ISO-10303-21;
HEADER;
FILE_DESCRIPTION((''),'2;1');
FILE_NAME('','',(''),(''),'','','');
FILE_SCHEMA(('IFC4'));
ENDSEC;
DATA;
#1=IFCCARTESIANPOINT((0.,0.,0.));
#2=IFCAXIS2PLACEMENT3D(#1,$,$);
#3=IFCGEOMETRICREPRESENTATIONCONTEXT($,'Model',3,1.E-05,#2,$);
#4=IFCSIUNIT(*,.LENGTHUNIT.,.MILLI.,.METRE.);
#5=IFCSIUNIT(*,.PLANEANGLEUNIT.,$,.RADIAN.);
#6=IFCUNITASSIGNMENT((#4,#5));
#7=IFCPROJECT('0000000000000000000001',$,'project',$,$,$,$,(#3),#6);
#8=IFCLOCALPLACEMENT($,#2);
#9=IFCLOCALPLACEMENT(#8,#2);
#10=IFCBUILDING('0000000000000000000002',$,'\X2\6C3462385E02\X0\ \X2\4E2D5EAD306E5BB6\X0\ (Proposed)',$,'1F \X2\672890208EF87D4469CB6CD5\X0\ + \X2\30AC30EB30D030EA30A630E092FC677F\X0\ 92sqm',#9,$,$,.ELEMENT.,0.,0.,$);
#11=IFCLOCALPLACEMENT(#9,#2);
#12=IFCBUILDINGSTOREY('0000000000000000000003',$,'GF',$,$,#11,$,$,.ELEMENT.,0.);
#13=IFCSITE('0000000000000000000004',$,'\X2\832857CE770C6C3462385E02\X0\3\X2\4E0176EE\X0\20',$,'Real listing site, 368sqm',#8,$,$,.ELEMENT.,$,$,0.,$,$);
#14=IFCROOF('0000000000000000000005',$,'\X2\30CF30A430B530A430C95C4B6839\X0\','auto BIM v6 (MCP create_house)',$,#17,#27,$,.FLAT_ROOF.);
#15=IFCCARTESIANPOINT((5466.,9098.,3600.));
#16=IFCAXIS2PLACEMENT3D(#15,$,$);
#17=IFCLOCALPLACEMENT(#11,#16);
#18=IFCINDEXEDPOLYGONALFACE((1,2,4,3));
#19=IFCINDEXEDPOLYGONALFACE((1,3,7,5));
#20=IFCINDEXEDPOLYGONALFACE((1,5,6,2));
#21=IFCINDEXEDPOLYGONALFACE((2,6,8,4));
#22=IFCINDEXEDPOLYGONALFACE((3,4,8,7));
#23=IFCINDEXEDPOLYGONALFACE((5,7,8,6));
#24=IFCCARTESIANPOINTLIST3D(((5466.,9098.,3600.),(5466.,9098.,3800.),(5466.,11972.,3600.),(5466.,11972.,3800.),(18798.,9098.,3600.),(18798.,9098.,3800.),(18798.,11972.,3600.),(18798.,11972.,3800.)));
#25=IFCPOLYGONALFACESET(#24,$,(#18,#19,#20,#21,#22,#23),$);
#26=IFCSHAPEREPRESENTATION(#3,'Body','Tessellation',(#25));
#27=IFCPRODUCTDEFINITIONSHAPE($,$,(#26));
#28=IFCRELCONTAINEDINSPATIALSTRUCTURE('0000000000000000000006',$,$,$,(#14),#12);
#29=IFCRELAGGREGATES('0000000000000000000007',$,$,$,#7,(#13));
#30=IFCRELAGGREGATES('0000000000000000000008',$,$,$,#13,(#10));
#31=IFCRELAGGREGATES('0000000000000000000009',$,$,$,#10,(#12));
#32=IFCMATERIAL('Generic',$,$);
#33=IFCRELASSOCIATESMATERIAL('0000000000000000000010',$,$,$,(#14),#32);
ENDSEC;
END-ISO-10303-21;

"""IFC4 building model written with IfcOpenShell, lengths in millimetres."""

from ifc_helpers import new_model, si_unit, frame, frame_2d, origin, place, context, project, spatial, rectangle, extrude, material, element, save


model = new_model("IFC4")

# Units and contexts
model_context = context("Model", 3, precision=1e-05, world=origin())
ifc_project = project(units=[si_unit("LENGTHUNIT", "METRE", prefix="MILLI"), si_unit("PLANEANGLEUNIT", "RADIAN")], contexts=[model_context])

# Site, building, storey
site_placement = place(None, origin())
site = spatial("IfcSite", under=ifc_project, at=site_placement, Name="茨城県水戸市3丁目20", ObjectType="Real listing site, 368sqm", CompositionType="ELEMENT", RefElevation=0.0)
building_placement = place(site_placement, origin())
building = spatial("IfcBuilding", under=site, at=building_placement, Name="水戸市 中庭の家 (Proposed)", ObjectType="1F 木造軸組構法 + ガルバリウム鋼板 92sqm", CompositionType="ELEMENT", ElevationOfRefHeight=0.0, ElevationOfTerrain=0.0)
storey_placement = place(building_placement, origin())
storey = spatial("IfcBuildingStorey", under=building, at=storey_placement, Name="GF", CompositionType="ELEMENT", Elevation=0.0)

# Shared definitions
ifc_material = material(Name="Generic")

# Roof
roof_1_placement = place(storey_placement, frame((5466.0, 9098.0, 3600.0)))
element("IfcRoof", 1, at=roof_1_placement, inside=storey, material=ifc_material, Name="ハイサイド屋根", Description="auto BIM v6 (MCP create_house)", PredefinedType="FLAT_ROOF", context=model_context, shape_type="SweptSolid", body=[
    extrude(rectangle(XDim=13332.0, YDim=2874.0, at=frame_2d((6666.0, 1437.0))), frame((5466.0, 9098.0, 3600.0)), (0.0, 0.0, 1.0), 200.0),
])

save(model, "model.ifc")
